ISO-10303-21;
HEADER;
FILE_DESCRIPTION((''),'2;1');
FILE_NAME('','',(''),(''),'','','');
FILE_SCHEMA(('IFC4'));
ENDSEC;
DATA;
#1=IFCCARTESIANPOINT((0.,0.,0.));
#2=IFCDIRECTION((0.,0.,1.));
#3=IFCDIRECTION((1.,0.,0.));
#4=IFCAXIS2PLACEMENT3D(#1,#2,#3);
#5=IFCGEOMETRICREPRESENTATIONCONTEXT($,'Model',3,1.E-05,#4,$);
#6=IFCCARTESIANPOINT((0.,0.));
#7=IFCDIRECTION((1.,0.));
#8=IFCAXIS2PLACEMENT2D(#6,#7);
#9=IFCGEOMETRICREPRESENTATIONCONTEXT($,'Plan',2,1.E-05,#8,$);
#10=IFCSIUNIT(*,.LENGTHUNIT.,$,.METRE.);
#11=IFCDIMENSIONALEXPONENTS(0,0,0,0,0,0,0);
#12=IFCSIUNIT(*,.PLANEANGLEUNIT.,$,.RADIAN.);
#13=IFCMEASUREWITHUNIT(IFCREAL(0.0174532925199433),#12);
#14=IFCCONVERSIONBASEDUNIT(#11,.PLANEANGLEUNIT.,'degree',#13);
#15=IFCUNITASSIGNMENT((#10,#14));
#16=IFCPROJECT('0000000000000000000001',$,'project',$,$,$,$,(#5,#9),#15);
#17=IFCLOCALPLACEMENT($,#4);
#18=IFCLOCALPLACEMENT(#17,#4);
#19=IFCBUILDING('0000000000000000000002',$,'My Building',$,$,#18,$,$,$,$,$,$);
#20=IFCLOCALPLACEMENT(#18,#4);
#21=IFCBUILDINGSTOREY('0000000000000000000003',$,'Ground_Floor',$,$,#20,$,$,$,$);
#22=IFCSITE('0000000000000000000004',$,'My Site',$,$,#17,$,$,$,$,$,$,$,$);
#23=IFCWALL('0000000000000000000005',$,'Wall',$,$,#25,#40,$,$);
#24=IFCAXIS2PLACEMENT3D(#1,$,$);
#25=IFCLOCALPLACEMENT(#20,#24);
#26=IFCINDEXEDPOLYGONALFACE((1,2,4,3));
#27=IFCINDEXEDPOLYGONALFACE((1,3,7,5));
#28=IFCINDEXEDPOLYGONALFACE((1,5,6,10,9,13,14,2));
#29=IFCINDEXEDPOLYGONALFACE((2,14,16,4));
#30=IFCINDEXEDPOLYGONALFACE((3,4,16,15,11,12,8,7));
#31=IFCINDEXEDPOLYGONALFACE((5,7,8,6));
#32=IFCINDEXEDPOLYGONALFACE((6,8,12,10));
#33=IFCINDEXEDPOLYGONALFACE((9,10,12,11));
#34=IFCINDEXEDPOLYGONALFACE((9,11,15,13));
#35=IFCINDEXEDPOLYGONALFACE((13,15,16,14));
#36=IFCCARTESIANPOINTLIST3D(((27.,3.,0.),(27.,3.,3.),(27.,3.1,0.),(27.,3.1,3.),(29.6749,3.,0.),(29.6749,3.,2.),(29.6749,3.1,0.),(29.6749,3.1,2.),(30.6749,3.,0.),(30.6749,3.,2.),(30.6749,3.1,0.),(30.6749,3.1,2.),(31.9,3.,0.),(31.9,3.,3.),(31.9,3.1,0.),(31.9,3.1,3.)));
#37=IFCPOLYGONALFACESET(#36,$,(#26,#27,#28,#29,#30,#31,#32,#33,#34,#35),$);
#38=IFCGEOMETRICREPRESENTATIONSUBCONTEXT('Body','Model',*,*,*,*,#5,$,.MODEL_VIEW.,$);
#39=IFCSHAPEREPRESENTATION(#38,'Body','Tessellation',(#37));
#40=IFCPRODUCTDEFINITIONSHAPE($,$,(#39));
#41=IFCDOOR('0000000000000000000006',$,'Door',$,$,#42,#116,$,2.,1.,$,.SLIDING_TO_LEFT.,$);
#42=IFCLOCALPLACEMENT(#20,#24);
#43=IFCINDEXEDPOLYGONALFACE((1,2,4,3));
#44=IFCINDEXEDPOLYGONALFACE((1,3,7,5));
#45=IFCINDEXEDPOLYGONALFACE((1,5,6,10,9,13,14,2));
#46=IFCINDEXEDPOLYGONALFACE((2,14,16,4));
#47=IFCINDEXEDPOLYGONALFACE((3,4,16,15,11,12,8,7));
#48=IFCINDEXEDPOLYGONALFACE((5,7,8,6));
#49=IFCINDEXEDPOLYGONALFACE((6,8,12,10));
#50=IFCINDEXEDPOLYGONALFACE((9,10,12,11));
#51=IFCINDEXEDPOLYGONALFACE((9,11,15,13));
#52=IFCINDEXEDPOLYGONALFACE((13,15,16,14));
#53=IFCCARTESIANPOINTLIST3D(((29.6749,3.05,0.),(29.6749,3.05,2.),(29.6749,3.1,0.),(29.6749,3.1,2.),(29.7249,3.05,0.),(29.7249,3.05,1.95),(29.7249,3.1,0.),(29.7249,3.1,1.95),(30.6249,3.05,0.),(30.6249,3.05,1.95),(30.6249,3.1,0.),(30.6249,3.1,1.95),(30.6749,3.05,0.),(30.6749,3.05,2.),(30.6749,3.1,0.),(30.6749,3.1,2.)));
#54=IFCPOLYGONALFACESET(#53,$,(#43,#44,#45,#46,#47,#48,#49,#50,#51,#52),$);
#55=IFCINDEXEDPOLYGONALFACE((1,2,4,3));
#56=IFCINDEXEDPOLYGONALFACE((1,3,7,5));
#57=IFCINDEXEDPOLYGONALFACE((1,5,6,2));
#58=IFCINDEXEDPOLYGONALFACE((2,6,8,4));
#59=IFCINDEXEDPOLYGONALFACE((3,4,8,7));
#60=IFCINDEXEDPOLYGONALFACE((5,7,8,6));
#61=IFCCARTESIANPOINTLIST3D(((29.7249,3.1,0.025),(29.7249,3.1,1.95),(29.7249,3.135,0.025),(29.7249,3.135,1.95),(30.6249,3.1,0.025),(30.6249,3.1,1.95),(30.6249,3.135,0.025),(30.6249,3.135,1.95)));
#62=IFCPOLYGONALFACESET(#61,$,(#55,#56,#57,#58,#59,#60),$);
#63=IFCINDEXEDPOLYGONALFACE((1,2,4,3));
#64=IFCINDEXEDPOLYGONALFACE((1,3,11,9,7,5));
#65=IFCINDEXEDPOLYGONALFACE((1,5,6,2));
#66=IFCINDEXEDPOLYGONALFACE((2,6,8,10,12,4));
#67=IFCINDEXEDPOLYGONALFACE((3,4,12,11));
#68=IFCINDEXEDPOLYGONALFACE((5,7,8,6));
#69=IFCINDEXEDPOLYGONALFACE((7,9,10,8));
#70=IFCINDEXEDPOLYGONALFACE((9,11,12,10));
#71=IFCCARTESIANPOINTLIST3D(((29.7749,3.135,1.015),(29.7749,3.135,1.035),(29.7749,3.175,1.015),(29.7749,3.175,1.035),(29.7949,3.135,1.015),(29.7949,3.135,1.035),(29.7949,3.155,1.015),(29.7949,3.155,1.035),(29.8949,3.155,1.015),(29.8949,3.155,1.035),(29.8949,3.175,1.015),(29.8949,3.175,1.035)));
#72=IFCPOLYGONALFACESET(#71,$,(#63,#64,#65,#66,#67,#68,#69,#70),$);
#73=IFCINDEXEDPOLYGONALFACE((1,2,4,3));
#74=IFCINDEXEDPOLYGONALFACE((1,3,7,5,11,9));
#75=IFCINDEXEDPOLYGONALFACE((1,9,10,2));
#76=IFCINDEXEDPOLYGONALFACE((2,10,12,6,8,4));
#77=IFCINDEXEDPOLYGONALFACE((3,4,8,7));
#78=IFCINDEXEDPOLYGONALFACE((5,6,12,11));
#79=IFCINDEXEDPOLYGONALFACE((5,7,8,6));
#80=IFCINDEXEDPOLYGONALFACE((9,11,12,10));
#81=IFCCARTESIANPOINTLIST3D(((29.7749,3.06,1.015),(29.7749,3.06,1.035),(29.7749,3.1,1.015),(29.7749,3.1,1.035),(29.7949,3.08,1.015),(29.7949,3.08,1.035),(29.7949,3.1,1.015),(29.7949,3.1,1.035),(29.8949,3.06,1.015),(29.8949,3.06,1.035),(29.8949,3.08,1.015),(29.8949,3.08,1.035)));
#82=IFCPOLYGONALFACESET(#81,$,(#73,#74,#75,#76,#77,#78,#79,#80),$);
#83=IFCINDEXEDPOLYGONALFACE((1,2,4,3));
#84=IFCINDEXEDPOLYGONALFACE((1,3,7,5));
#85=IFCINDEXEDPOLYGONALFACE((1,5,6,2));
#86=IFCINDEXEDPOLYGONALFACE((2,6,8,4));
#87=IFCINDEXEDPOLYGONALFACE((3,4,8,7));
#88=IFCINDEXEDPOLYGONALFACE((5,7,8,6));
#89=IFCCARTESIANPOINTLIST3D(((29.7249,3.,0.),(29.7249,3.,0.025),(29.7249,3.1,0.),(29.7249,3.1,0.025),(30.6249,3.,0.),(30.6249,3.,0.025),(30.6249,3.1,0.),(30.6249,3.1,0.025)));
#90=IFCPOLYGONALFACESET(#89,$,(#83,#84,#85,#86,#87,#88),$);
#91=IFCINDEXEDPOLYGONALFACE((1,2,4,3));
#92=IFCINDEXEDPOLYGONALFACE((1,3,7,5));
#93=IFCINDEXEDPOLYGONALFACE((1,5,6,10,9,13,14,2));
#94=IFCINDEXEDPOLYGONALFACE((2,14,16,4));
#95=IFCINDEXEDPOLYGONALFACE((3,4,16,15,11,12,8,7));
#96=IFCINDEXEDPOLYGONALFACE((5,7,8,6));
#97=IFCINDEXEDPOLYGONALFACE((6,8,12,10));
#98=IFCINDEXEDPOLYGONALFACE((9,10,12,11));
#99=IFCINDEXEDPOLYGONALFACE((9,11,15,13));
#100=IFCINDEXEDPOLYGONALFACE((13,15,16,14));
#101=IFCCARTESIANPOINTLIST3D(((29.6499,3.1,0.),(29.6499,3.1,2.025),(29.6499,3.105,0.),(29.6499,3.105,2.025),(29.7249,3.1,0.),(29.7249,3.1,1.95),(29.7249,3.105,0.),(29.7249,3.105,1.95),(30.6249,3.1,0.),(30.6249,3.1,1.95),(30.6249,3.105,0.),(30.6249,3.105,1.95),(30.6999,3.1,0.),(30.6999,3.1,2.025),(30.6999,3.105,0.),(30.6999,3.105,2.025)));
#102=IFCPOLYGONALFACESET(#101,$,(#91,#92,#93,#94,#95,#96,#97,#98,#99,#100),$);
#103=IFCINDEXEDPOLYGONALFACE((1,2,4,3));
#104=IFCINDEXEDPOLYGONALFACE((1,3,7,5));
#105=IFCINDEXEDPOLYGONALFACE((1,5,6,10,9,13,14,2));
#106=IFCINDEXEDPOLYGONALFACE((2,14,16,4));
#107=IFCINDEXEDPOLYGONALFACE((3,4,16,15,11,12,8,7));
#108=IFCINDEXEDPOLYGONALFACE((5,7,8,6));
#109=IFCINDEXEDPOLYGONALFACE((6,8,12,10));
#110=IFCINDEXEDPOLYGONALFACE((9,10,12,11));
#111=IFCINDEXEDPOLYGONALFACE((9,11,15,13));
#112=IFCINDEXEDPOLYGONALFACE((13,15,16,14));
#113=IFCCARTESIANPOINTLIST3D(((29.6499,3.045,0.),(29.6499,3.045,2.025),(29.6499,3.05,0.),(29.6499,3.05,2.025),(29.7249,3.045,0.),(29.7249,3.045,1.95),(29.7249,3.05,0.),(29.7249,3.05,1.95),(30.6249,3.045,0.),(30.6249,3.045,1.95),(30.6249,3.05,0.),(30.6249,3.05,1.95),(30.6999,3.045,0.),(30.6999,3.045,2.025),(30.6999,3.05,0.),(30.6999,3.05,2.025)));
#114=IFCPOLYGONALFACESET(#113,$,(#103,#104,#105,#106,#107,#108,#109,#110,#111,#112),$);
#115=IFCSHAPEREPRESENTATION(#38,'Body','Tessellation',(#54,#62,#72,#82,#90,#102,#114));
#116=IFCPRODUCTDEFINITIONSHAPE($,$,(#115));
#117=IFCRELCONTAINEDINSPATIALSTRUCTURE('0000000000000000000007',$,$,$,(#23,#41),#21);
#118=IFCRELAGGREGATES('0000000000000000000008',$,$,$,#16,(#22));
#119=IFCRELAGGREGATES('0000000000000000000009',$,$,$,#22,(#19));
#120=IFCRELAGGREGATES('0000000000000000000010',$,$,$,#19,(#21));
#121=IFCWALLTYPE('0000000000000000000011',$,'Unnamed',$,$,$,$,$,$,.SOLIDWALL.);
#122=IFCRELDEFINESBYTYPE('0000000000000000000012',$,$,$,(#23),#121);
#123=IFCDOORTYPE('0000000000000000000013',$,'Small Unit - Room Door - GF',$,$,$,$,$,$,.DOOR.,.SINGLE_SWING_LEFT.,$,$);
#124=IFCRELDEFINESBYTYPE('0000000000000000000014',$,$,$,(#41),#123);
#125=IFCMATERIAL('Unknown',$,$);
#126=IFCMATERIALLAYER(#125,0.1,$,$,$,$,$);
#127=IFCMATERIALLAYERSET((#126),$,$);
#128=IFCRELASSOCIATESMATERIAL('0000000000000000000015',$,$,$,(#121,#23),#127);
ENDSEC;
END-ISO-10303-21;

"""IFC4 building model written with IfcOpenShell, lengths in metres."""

from ifc_helpers import new_model, entity, si_unit, converted_unit, frame, origin_with_axes, origin_2d_with_axis, place, context, subcontext, project, spatial, line, indexed_curve, outline, extrude, shape, source, transform, mapped, material, layer, layer_set, layer_usage, type_object, type_shapes, element, fill, save


model = new_model("IFC4")

# Units and contexts
model_context = context("Model", 3, precision=1e-05, world=origin_with_axes())
plan_context = context("Plan", 2, precision=1e-05, world=origin_2d_with_axis())
body_context_1 = subcontext(model_context, "Body", "Model", "MODEL_VIEW")
body_context_2 = subcontext(plan_context, "Body", "Plan", "PLAN_VIEW")
ifc_project = project(units=[si_unit("LENGTHUNIT", "METRE"), converted_unit("PLANEANGLEUNIT", "degree", entity("IfcReal", 0.0174532925199433), si_unit("PLANEANGLEUNIT", "RADIAN"), dimensions=[0, 0, 0, 0, 0, 0, 0])], contexts=[model_context, plan_context])

# Site, building, storey
site_placement = place(None, origin_with_axes())
site = spatial("IfcSite", under=ifc_project, at=site_placement, Name="My Site")
building_placement = place(site_placement, origin_with_axes())
building = spatial("IfcBuilding", under=site, at=building_placement, Name="My Building")
storey_placement = place(building_placement, origin_with_axes())
storey = spatial("IfcBuildingStorey", under=building, at=storey_placement, Name="Ground_Floor")

# Shared definitions
ifc_material = material(Name="Unknown")
ifc_layer = layer(ifc_material, 0.1)
ifc_layer_set = layer_set([ifc_layer])
wall_type = type_object("IfcWallType", Name="Unnamed", PredefinedType="SOLIDWALL", material=ifc_layer_set)

# Shared definitions
shared_shape_1 = source(origin_with_axes(), body_context_1, "Body", "SweptSolid", [
    extrude(outline(indexed_curve([(0.0, 0.0), (1.0, 0.0), (1.0, 2.0), (0.0, 2.0)], segments=[line(1, 2, 3, 4, 1)])), frame((0.0, -0.6, 0.0), z_axis=(0.0, -1.0, 0.0), x_axis=(1.0, 0.0, 0.0)), (0.0, 0.0, -1.0), 1.2),
])
door_type_1 = type_object("IfcDoorType", Name="Small Unit - Room Door - GF", OperationType="SINGLE_SWING_LEFT", PredefinedType="DOOR")
shared_shape_2 = source(origin_with_axes(), body_context_1, "Body", "SweptSolid", [
    extrude(outline(indexed_curve([(0.0, 0.0), (0.0, 2.0), (1.0, 2.0), (1.0, 0.0), (0.95, 0.0), (0.95, 1.95), (0.05, 1.95), (0.05, 0.0)], segments=[line(1, 2, 3, 4, 5, 6, 7, 8, 1)])), frame((0.0, 0.0, 0.0), z_axis=(0.0, -1.0, 0.0), x_axis=(1.0, 0.0, 0.0)), (0.0, 0.0, -1.0), 0.05),
    extrude(outline(indexed_curve([(0.0, 0.0), (0.9, 0.0), (0.9, 0.035), (0.0, 0.035)], segments=[line(1, 2, 3, 4, 1)])), frame((0.05, -0.035, 0.025), z_axis=(0.0, 0.0, 1.0), x_axis=(1.0, 0.0, 0.0)), (0.0, 0.0, 1.0), 1.925),
    extrude(outline(indexed_curve([(0.0, 0.0), (0.0, -0.04), (-0.12, -0.04), (-0.12, -0.02), (-0.02, -0.02), (-0.02, 0.0)], segments=[line(1, 2, 3, 4, 5, 6, 1)])), frame((0.9, -0.035, 1.015), z_axis=(0.0, 0.0, 1.0), x_axis=(1.0, 0.0, 0.0)), (0.0, 0.0, 1.0), 0.02),
    extrude(outline(indexed_curve([(0.0, 0.0), (0.0, 0.04), (-0.12, 0.04), (-0.12, 0.02), (-0.02, 0.02), (-0.02, 0.0)], segments=[line(1, 2, 3, 4, 5, 6, 1)])), frame((0.9, 0.0, 1.015), z_axis=(0.0, 0.0, 1.0), x_axis=(1.0, 0.0, 0.0)), (0.0, 0.0, 1.0), 0.02),
    extrude(outline(indexed_curve([(0.0, 0.0), (0.9, 0.0), (0.9, 0.1), (0.0, 0.1)], segments=[line(1, 2, 3, 4, 1)])), frame((0.05, 0.0, 0.0), z_axis=(0.0, 0.0, 1.0), x_axis=(1.0, 0.0, 0.0)), (0.0, 0.0, 1.0), 0.025),
    extrude(outline(indexed_curve([(0.0, 0.0), (0.0, 2.025), (1.05, 2.025), (1.05, 0.0), (0.975, 0.0), (0.975, 1.95), (0.075, 1.95), (0.075, 0.0)], segments=[line(1, 2, 3, 4, 5, 6, 7, 8, 1)])), frame((-0.025, -0.005, 0.0), z_axis=(0.0, -1.0, 0.0), x_axis=(1.0, 0.0, 0.0)), (0.0, 0.0, -1.0), 0.005),
    extrude(outline(indexed_curve([(0.0, 0.0), (0.0, 2.025), (1.05, 2.025), (1.05, 0.0), (0.975, 0.0), (0.975, 1.95), (0.075, 1.95), (0.075, 0.0)], segments=[line(1, 2, 3, 4, 5, 6, 7, 8, 1)])), frame((-0.025, 0.05, 0.0), z_axis=(0.0, -1.0, 0.0), x_axis=(1.0, 0.0, 0.0)), (0.0, 0.0, -1.0), 0.005),
])
shared_shape_3 = source(origin_with_axes(), body_context_2, "Body", "Curve2D", [
    entity("IfcIndexedPolyCurve", entity("IfcCartesianPointList2D", [[0.0, 0.0], [0.05, 0.0], [0.05, 0.05], [0.0, 0.05]]), [entity("IfcLineIndex", [1, 2, 3, 4, 1])]),
    entity("IfcIndexedPolyCurve", entity("IfcCartesianPointList2D", [[1.0, 0.0], [0.95, 0.0], [0.95, 0.05], [1.0, 0.05]]), [entity("IfcLineIndex", [1, 2, 3, 4, 1])]),
    entity("IfcIndexedPolyCurve", entity("IfcCartesianPointList2D", [[-0.4, -0.035], [0.5, -0.035], [0.5, 0.0], [-0.4, 0.0]]), [entity("IfcLineIndex", [1, 2, 3, 4, 1])]),
])
type_shapes(door_type_1, [shared_shape_2, shared_shape_3])

# Wall, opening, door
ifc_layer_usage_1 = layer_usage(ifc_layer_set, "AXIS2", "POSITIVE", 0.0)
wall_1_placement = place(storey_placement, frame((27.0, 3.0, 0.0), z_axis=(0.0, 0.0, 1.0), x_axis=(1.0, 0.0, 0.0)))
wall_1 = element("IfcWall", 1, at=wall_1_placement, inside=storey, type_object=wall_type, material=ifc_layer_usage_1, Name="Wall", context=body_context_1, shape_type="SweptSolid", body=[
    extrude(outline(indexed_curve([(0.0, 0.0), (0.0, 0.1), (4.9, 0.1), (4.9, 0.0)], segments=[line(1, 2, 3, 4, 1)])), origin_with_axes(), (0.0, 0.0, 1.0), 3.0),
])
opening_1_placement = place(wall_1_placement, frame((3.6749, 0.1, 0.0), z_axis=(0.0, 0.0, 1.0), x_axis=(-1.0, 0.0, 0.0)))
opening_1 = element("IfcOpeningElement", 2, at=opening_1_placement, cuts=wall_1, PredefinedType="OPENING", context=body_context_1, shape_type="MappedRepresentation", body=[
    mapped(shared_shape_1, transform((0.0, 0.0, 0.0), x_axis=(1.0, 0.0, 0.0), y_axis=(0.0, 1.0, 0.0), z_axis=(0.0, 0.0, 1.0), scale=1.0)),
])
door_1_placement = place(opening_1_placement, origin_with_axes())
door_1 = element("IfcDoor", 3, at=door_1_placement, inside=storey, type_object=door_type_1, Name="Door", OperationType="SLIDING_TO_LEFT", OverallHeight=2.0, OverallWidth=1.0, shapes=[
    shape(body_context_1, "Body", "MappedRepresentation", [mapped(shared_shape_2, transform((0.0, 0.0, 0.0), x_axis=(1.0, 0.0, 0.0), y_axis=(0.0, 1.0, 0.0), z_axis=(0.0, 0.0, 1.0), scale=1.0))]),
    shape(body_context_2, "Body", "MappedRepresentation", [mapped(shared_shape_3, transform((0.0, 0.0, 0.0), x_axis=(1.0, 0.0, 0.0), y_axis=(0.0, 1.0, 0.0), z_axis=(0.0, 0.0, 1.0), scale=1.0))]),
])
fill(opening_1, door_1)

save(model, "model.ifc")
